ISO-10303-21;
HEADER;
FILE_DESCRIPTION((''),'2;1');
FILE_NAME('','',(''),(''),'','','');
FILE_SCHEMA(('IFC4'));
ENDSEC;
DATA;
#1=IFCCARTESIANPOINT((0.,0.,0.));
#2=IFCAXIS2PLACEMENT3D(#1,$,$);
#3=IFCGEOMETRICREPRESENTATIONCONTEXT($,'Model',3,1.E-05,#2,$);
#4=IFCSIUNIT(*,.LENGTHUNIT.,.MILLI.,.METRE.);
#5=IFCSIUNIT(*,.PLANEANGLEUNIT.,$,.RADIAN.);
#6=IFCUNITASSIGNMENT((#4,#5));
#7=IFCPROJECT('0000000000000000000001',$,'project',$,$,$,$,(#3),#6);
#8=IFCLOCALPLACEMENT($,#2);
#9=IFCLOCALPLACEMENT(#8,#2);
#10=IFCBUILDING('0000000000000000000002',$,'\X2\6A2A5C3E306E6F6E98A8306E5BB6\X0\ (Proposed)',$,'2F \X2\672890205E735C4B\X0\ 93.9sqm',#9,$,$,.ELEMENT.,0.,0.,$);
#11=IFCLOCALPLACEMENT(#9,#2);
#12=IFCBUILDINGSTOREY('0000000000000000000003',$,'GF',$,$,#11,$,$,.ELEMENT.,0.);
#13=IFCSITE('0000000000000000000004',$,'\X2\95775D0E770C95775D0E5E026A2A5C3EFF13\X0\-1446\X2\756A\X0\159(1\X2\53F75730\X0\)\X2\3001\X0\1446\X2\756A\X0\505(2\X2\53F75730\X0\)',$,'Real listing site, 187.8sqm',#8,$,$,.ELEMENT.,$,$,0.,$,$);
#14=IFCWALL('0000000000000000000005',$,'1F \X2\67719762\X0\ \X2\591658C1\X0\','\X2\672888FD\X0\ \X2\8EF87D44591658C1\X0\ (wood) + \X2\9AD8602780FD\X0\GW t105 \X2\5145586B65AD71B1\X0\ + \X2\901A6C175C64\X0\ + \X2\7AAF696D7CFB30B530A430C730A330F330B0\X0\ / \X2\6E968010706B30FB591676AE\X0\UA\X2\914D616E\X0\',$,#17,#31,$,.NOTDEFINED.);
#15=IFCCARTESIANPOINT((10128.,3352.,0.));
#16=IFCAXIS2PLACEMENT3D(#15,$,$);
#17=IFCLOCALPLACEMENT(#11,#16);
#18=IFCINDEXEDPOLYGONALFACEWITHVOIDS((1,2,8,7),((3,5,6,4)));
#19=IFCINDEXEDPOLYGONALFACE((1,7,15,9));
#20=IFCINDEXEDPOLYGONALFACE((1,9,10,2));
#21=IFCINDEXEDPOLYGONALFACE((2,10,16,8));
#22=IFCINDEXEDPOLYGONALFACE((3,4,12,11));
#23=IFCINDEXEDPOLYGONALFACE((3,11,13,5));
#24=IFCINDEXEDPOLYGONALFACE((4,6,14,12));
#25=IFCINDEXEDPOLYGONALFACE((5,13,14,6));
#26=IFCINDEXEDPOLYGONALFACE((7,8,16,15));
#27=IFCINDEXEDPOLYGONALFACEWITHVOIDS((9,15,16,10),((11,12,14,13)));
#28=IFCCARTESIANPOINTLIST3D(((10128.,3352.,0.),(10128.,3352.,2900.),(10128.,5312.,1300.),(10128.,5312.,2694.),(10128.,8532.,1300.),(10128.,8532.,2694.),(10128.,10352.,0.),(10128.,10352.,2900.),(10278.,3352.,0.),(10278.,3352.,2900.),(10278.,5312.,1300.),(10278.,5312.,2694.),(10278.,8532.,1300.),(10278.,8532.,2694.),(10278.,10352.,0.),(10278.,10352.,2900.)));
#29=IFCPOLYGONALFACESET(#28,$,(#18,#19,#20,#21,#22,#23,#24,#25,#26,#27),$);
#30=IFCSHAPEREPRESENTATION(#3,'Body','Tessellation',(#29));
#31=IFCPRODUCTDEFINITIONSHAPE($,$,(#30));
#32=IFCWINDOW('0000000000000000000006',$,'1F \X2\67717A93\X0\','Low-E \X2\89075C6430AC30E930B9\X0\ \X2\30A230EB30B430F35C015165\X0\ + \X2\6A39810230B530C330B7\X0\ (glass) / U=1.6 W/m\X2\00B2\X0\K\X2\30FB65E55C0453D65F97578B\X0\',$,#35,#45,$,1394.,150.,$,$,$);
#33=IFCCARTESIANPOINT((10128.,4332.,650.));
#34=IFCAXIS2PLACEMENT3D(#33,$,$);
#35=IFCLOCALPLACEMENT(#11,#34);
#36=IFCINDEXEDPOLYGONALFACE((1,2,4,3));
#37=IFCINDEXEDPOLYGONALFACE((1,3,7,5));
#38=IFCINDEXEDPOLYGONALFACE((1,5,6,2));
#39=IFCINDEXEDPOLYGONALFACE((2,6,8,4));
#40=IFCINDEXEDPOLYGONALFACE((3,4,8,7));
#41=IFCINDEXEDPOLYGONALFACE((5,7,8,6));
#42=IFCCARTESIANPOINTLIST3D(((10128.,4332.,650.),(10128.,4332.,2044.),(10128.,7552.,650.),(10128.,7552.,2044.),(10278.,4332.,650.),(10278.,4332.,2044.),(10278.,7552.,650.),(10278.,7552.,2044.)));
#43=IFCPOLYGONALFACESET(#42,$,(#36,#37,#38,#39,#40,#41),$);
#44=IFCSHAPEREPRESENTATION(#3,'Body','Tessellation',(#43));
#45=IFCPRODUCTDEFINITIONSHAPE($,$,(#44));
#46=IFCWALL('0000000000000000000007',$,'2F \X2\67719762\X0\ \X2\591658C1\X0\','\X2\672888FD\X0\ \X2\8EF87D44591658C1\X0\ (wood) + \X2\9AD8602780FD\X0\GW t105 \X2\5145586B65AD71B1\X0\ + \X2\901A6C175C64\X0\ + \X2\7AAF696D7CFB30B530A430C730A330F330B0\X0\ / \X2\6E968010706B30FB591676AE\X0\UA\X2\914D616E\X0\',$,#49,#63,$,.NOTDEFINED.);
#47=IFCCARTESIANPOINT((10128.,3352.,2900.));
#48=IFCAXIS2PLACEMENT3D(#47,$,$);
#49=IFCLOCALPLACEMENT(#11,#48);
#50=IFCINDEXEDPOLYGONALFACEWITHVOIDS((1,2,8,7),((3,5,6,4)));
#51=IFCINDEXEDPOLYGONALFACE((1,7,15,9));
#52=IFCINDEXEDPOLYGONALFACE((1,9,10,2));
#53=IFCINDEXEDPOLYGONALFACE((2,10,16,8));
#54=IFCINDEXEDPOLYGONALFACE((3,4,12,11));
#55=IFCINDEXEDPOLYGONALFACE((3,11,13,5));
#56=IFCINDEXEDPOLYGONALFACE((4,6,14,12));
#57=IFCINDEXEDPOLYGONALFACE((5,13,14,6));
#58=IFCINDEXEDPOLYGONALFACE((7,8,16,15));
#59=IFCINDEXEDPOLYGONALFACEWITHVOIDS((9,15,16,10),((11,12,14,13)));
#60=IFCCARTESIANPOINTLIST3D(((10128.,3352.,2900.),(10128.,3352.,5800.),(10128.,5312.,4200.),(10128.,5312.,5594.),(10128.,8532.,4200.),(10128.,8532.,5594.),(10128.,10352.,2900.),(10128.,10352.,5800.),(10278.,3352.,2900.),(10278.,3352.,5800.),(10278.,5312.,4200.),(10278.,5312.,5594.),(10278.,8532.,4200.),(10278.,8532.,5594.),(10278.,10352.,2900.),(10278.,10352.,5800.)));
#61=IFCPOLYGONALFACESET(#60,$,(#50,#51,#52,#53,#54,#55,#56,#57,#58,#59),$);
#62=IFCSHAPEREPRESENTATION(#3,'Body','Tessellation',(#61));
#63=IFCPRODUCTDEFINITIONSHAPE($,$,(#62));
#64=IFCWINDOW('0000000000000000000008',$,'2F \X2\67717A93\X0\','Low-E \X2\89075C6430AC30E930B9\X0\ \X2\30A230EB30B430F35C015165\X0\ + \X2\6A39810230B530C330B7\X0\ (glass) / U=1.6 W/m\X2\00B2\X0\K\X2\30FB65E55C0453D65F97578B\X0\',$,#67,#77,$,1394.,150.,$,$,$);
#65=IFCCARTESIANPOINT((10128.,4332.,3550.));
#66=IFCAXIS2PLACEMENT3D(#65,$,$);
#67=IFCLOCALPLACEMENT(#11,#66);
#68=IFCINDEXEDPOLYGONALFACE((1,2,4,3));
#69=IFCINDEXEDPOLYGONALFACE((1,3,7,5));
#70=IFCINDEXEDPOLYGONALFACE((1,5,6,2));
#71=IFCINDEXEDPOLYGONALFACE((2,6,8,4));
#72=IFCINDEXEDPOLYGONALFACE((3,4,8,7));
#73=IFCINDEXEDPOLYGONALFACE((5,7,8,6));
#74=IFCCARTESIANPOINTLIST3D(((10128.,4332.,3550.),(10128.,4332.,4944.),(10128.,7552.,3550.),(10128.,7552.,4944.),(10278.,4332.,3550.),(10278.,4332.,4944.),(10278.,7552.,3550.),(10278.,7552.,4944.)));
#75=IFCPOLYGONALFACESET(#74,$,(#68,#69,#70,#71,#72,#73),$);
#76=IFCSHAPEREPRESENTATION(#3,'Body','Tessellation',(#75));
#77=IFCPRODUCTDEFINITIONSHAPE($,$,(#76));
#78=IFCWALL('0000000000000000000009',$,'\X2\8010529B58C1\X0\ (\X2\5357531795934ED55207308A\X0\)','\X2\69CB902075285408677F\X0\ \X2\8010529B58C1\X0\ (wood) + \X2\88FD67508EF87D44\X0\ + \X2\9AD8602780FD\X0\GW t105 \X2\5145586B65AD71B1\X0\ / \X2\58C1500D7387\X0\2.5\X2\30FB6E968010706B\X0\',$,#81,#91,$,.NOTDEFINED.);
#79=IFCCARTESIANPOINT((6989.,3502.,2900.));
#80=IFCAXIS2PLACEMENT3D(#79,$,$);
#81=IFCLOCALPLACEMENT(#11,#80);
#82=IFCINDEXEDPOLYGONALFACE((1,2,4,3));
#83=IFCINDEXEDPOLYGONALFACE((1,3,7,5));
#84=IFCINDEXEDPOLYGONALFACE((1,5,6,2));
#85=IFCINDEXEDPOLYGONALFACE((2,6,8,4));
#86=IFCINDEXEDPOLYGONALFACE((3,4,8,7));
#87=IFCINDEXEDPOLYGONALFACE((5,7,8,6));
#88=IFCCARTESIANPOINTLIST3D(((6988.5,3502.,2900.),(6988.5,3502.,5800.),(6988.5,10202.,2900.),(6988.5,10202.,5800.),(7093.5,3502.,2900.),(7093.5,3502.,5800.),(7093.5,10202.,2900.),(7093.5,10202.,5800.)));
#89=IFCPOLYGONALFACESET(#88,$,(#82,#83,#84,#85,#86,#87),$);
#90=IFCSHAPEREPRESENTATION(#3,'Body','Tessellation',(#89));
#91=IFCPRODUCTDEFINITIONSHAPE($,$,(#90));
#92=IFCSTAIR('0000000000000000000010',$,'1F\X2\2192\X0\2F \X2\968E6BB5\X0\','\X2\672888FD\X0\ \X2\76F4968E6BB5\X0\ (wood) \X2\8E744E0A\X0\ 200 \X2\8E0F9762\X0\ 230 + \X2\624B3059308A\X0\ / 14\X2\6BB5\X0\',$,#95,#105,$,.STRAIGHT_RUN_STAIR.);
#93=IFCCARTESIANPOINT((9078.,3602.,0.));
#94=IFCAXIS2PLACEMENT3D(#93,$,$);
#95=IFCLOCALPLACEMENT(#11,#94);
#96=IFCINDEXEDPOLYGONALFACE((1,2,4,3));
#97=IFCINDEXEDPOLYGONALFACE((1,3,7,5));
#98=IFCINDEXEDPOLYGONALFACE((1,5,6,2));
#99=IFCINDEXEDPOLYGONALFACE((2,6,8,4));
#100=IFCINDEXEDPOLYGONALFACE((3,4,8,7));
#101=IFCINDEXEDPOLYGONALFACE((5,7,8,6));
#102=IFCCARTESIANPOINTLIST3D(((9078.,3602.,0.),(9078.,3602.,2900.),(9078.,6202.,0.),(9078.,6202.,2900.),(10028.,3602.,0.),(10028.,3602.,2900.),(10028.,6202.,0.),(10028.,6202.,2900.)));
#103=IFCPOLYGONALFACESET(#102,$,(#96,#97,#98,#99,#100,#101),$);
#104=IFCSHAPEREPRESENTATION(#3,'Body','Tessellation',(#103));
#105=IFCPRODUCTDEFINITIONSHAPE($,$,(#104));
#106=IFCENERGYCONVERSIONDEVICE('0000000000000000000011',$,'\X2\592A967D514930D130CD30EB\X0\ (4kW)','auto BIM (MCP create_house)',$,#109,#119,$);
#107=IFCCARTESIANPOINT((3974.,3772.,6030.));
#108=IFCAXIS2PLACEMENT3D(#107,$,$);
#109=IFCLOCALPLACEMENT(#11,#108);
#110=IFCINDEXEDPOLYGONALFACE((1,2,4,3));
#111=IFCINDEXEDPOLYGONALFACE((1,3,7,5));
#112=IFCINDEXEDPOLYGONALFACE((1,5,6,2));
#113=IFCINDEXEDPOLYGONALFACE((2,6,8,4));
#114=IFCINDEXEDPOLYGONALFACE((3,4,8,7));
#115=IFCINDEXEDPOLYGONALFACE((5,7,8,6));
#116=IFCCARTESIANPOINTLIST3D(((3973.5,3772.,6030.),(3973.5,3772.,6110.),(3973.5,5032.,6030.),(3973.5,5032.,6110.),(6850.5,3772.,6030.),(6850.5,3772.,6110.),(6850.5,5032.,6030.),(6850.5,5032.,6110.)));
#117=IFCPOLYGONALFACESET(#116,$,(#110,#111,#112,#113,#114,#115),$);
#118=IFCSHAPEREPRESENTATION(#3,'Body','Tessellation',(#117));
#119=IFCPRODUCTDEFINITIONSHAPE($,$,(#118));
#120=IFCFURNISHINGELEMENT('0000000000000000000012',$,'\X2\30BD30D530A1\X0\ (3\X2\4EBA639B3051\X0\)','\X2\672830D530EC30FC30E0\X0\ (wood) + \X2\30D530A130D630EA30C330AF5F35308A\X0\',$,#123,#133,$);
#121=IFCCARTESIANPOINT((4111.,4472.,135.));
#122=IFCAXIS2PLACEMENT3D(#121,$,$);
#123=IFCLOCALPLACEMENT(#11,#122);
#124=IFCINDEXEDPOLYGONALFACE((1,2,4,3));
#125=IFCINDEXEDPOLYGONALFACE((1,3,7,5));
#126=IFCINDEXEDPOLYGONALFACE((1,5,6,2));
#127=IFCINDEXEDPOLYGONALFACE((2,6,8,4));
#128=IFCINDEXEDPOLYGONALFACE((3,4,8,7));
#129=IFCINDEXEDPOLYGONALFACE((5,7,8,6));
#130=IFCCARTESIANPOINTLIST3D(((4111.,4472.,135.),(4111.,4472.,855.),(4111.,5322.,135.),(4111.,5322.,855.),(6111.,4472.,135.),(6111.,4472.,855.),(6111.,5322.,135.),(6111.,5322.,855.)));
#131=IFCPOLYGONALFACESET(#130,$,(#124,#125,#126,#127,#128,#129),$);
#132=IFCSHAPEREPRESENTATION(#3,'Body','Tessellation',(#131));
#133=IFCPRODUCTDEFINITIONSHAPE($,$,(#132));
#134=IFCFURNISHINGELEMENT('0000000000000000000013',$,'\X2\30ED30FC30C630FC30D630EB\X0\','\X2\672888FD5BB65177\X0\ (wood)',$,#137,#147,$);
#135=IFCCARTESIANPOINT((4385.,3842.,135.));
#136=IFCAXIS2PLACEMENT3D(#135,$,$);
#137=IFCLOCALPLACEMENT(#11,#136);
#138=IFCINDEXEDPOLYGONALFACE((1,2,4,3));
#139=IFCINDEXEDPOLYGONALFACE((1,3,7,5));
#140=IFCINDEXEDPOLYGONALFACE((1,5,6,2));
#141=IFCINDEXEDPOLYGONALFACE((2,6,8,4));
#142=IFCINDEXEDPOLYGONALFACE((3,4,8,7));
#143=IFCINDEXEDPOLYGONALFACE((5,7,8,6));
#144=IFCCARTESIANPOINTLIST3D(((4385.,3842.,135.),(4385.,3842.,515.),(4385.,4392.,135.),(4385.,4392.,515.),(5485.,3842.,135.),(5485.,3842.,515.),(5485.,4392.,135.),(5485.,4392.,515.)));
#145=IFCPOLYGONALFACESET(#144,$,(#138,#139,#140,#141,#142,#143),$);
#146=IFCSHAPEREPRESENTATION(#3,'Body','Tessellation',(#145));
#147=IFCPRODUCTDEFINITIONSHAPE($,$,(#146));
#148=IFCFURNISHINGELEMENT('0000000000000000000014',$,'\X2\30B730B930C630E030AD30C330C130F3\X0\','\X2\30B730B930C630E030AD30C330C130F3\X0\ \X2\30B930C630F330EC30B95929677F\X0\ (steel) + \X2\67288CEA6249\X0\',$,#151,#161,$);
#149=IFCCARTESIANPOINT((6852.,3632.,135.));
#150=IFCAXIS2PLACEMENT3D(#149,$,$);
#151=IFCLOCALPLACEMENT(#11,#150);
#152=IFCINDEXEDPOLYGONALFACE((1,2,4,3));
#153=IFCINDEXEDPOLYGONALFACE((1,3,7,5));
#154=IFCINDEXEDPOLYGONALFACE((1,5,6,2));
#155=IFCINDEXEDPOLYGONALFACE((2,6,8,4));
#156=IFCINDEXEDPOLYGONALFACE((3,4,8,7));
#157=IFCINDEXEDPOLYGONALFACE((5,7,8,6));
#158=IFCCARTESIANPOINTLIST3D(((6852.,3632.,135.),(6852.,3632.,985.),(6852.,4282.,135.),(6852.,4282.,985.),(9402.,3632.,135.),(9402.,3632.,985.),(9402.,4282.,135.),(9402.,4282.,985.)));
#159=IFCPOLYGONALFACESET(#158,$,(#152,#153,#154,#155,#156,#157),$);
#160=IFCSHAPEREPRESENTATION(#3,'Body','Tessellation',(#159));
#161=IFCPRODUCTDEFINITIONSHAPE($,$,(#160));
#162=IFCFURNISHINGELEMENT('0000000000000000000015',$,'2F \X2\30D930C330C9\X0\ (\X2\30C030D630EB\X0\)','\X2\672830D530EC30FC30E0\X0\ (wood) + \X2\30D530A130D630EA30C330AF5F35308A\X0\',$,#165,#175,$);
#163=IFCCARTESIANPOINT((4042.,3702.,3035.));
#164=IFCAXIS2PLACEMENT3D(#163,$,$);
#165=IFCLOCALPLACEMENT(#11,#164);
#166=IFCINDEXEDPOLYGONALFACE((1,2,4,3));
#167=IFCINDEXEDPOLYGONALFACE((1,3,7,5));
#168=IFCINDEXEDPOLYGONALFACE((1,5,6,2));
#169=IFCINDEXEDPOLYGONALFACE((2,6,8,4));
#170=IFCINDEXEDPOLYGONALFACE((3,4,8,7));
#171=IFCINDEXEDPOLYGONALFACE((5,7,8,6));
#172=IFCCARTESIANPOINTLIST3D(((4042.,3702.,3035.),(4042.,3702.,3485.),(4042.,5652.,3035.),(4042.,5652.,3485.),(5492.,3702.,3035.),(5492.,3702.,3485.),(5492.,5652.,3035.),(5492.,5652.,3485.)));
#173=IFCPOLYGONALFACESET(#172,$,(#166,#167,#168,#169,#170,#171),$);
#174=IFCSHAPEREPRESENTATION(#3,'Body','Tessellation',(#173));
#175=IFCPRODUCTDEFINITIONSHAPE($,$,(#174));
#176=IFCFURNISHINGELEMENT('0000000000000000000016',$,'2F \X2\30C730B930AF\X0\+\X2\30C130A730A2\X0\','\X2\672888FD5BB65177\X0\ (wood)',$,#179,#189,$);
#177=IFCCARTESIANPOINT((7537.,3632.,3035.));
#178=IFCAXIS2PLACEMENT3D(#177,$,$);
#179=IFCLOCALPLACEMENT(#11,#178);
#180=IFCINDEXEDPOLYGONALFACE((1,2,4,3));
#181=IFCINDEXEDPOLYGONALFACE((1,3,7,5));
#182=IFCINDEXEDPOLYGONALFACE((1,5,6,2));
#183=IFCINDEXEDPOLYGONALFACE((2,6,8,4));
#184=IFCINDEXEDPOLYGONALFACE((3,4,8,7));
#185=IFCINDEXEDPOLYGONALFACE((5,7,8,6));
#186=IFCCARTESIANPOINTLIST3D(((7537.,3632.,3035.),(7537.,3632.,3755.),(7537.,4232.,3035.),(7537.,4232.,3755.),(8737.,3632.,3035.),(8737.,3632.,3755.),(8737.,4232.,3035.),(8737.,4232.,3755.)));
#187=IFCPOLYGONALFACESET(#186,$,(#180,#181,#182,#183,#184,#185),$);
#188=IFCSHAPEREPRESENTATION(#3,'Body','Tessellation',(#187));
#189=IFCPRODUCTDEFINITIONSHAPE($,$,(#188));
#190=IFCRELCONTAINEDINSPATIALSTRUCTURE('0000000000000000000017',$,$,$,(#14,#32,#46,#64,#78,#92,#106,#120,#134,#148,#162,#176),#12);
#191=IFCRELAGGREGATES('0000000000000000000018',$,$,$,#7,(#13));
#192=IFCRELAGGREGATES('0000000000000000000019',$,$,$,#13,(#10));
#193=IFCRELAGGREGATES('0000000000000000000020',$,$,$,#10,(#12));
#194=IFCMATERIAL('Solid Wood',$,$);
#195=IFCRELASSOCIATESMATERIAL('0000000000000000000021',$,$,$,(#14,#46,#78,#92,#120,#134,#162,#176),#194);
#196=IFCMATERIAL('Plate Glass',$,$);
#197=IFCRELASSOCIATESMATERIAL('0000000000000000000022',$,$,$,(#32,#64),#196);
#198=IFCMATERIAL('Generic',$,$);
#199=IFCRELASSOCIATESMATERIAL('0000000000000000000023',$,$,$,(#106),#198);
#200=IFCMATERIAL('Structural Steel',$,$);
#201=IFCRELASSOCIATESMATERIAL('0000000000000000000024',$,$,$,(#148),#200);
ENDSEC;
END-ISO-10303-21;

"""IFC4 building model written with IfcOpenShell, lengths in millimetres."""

from ifc_helpers import new_model, si_unit, frame, frame_2d, origin, place, context, project, spatial, rectangle, extrude, material, element, fill, save


model = new_model("IFC4")

# Units and contexts
model_context = context("Model", 3, precision=1e-05, world=origin())
ifc_project = project(units=[si_unit("LENGTHUNIT", "METRE", prefix="MILLI"), si_unit("PLANEANGLEUNIT", "RADIAN")], contexts=[model_context])

# Site, building, storey
site_placement = place(None, origin())
site = spatial("IfcSite", under=ifc_project, at=site_placement, Name="長崎県長崎市横尾３-1446番159(1号地)、1446番505(2号地)", ObjectType="Real listing site, 187.8sqm", CompositionType="ELEMENT", RefElevation=0.0)
building_placement = place(site_placement, origin())
building = spatial("IfcBuilding", under=site, at=building_placement, Name="横尾の潮風の家 (Proposed)", ObjectType="2F 木造平屋 93.9sqm", CompositionType="ELEMENT", ElevationOfRefHeight=0.0, ElevationOfTerrain=0.0)
storey_placement = place(building_placement, origin())
storey = spatial("IfcBuildingStorey", under=building, at=storey_placement, Name="GF", CompositionType="ELEMENT", Elevation=0.0)

# Wall, opening, window
ifc_material_1 = material(Name="Solid Wood")
wall_1_placement = place(storey_placement, frame((10128.0, 3352.0, 0.0)))
wall_1 = element("IfcWall", 1, at=wall_1_placement, inside=storey, material=ifc_material_1, Name="1F 東面 外壁", Description="木製 軸組外壁 (wood) + 高性能GW t105 充填断熱 + 通気層 + 窯業系サイディング / 準耐火・外皮UA配慮", PredefinedType="NOTDEFINED", context=model_context, shape_type="SweptSolid", body=[
    extrude(rectangle(XDim=150.0, YDim=7000.0, at=frame_2d((75.0, 3500.0))), frame((10128.0, 3352.0, 0.0)), (0.0, 0.0, 1.0), 2900.0),
])
opening_1_placement = place(storey_placement, frame((10128.0, 4332.0, 650.0)))
opening_1 = element("IfcOpeningElement", 2, at=opening_1_placement, cuts=wall_1, PredefinedType="NOTDEFINED", context=model_context, shape_type="SweptSolid", body=[
    extrude(rectangle(XDim=150.0, YDim=3220.0, at=frame_2d((75.0, 1610.0))), frame((10128.0, 4332.0, 650.0)), (0.0, 0.0, 1.0), 1394.0),
])
ifc_material_2 = material(Name="Plate Glass")
window_1_placement = place(storey_placement, frame((10128.0, 4332.0, 650.0)))
window_1 = element("IfcWindow", 3, at=window_1_placement, inside=storey, material=ifc_material_2, Name="1F 東窓", Description="Low-E 複層ガラス アルゴン封入 + 樹脂サッシ (glass) / U=1.6 W/m²K・日射取得型", OverallHeight=1394.0, OverallWidth=150.0, context=model_context, shape_type="SweptSolid", body=[
    extrude(rectangle(XDim=150.0, YDim=3220.0, at=frame_2d((75.0, 1610.0))), frame((10128.0, 4332.0, 650.0)), (0.0, 0.0, 1.0), 1394.0),
])
fill(opening_1, window_1)

# Wall, opening, window
wall_2_placement = place(storey_placement, frame((10128.0, 3352.0, 2900.0)))
wall_2 = element("IfcWall", 4, at=wall_2_placement, inside=storey, material=ifc_material_1, Name="2F 東面 外壁", Description="木製 軸組外壁 (wood) + 高性能GW t105 充填断熱 + 通気層 + 窯業系サイディング / 準耐火・外皮UA配慮", PredefinedType="NOTDEFINED", context=model_context, shape_type="SweptSolid", body=[
    extrude(rectangle(XDim=150.0, YDim=7000.0, at=frame_2d((75.0, 3500.0))), frame((10128.0, 3352.0, 2900.0)), (0.0, 0.0, 1.0), 2900.0),
])
opening_2_placement = place(storey_placement, frame((10128.0, 4332.0, 3550.0)))
opening_2 = element("IfcOpeningElement", 5, at=opening_2_placement, cuts=wall_2, PredefinedType="NOTDEFINED", context=model_context, shape_type="SweptSolid", body=[
    extrude(rectangle(XDim=150.0, YDim=3220.0, at=frame_2d((75.0, 1610.0))), frame((10128.0, 4332.0, 3550.0)), (0.0, 0.0, 1.0), 1394.0),
])
window_2_placement = place(storey_placement, frame((10128.0, 4332.0, 3550.0)))
window_2 = element("IfcWindow", 6, at=window_2_placement, inside=storey, material=ifc_material_2, Name="2F 東窓", Description="Low-E 複層ガラス アルゴン封入 + 樹脂サッシ (glass) / U=1.6 W/m²K・日射取得型", OverallHeight=1394.0, OverallWidth=150.0, context=model_context, shape_type="SweptSolid", body=[
    extrude(rectangle(XDim=150.0, YDim=3220.0, at=frame_2d((75.0, 1610.0))), frame((10128.0, 4332.0, 3550.0)), (0.0, 0.0, 1.0), 1394.0),
])
fill(opening_2, window_2)

# Wall
wall_3_placement = place(storey_placement, frame((6989.0, 3502.0, 2900.0)))
element("IfcWall", 7, at=wall_3_placement, inside=storey, material=ifc_material_1, Name="耐力壁 (南北間仕切り)", Description="構造用合板 耐力壁 (wood) + 製材軸組 + 高性能GW t105 充填断熱 / 壁倍率2.5・準耐火", PredefinedType="NOTDEFINED", context=model_context, shape_type="SweptSolid", body=[
    extrude(rectangle(XDim=105.0, YDim=6700.0, at=frame_2d((52.0, 3350.0))), frame((6989.0, 3502.0, 2900.0)), (0.0, 0.0, 1.0), 2900.0),
])

# Stair
stair_placement = place(storey_placement, frame((9078.0, 3602.0, 0.0)))
element("IfcStair", 8, at=stair_placement, inside=storey, material=ifc_material_1, Name="1F→2F 階段", Description="木製 直階段 (wood) 蹴上 200 踏面 230 + 手すり / 14段", PredefinedType="STRAIGHT_RUN_STAIR", context=model_context, shape_type="SweptSolid", body=[
    extrude(rectangle(XDim=950.0, YDim=2600.0, at=frame_2d((475.0, 1300.0))), frame((9078.0, 3602.0, 0.0)), (0.0, 0.0, 1.0), 2900.0),
])

# Energy conversion device
ifc_material_3 = material(Name="Generic")
energy_conversion_device_placement = place(storey_placement, frame((3974.0, 3772.0, 6030.0)))
element("IfcEnergyConversionDevice", 9, at=energy_conversion_device_placement, inside=storey, material=ifc_material_3, Name="太陽光パネル (4kW)", Description="auto BIM (MCP create_house)", context=model_context, shape_type="SweptSolid", body=[
    extrude(rectangle(XDim=2877.0, YDim=1260.0, at=frame_2d((1438.0, 630.0))), frame((3974.0, 3772.0, 6030.0)), (0.0, 0.0, 1.0), 80.0),
])

# Furnishing elements
furnishing_1_placement = place(storey_placement, frame((4111.0, 4472.0, 135.0)))
element("IfcFurnishingElement", 10, at=furnishing_1_placement, inside=storey, material=ifc_material_1, Name="ソファ (3人掛け)", Description="木フレーム (wood) + ファブリック張り", context=model_context, shape_type="SweptSolid", body=[
    extrude(rectangle(XDim=2000.0, YDim=850.0, at=frame_2d((1000.0, 425.0))), frame((4111.0, 4472.0, 135.0)), (0.0, 0.0, 1.0), 720.0),
])
furnishing_2_placement = place(storey_placement, frame((4385.0, 3842.0, 135.0)))
element("IfcFurnishingElement", 11, at=furnishing_2_placement, inside=storey, material=ifc_material_1, Name="ローテーブル", Description="木製家具 (wood)", context=model_context, shape_type="SweptSolid", body=[
    extrude(rectangle(XDim=1100.0, YDim=550.0, at=frame_2d((550.0, 275.0))), frame((4385.0, 3842.0, 135.0)), (0.0, 0.0, 1.0), 380.0),
])
ifc_material_4 = material(Name="Structural Steel")
furnishing_3_placement = place(storey_placement, frame((6852.0, 3632.0, 135.0)))
element("IfcFurnishingElement", 12, at=furnishing_3_placement, inside=storey, material=ifc_material_4, Name="システムキッチン", Description="システムキッチン ステンレス天板 (steel) + 木質扉", context=model_context, shape_type="SweptSolid", body=[
    extrude(rectangle(XDim=2550.0, YDim=650.0, at=frame_2d((1275.0, 325.0))), frame((6852.0, 3632.0, 135.0)), (0.0, 0.0, 1.0), 850.0),
])
furnishing_4_placement = place(storey_placement, frame((4042.0, 3702.0, 3035.0)))
element("IfcFurnishingElement", 13, at=furnishing_4_placement, inside=storey, material=ifc_material_1, Name="2F ベッド (ダブル)", Description="木フレーム (wood) + ファブリック張り", context=model_context, shape_type="SweptSolid", body=[
    extrude(rectangle(XDim=1450.0, YDim=1950.0, at=frame_2d((725.0, 975.0))), frame((4042.0, 3702.0, 3035.0)), (0.0, 0.0, 1.0), 450.0),
])
furnishing_5_placement = place(storey_placement, frame((7537.0, 3632.0, 3035.0)))
element("IfcFurnishingElement", 14, at=furnishing_5_placement, inside=storey, material=ifc_material_1, Name="2F デスク+チェア", Description="木製家具 (wood)", context=model_context, shape_type="SweptSolid", body=[
    extrude(rectangle(XDim=1200.0, YDim=600.0, at=frame_2d((600.0, 300.0))), frame((7537.0, 3632.0, 3035.0)), (0.0, 0.0, 1.0), 720.0),
])

save(model, "model.ifc")
